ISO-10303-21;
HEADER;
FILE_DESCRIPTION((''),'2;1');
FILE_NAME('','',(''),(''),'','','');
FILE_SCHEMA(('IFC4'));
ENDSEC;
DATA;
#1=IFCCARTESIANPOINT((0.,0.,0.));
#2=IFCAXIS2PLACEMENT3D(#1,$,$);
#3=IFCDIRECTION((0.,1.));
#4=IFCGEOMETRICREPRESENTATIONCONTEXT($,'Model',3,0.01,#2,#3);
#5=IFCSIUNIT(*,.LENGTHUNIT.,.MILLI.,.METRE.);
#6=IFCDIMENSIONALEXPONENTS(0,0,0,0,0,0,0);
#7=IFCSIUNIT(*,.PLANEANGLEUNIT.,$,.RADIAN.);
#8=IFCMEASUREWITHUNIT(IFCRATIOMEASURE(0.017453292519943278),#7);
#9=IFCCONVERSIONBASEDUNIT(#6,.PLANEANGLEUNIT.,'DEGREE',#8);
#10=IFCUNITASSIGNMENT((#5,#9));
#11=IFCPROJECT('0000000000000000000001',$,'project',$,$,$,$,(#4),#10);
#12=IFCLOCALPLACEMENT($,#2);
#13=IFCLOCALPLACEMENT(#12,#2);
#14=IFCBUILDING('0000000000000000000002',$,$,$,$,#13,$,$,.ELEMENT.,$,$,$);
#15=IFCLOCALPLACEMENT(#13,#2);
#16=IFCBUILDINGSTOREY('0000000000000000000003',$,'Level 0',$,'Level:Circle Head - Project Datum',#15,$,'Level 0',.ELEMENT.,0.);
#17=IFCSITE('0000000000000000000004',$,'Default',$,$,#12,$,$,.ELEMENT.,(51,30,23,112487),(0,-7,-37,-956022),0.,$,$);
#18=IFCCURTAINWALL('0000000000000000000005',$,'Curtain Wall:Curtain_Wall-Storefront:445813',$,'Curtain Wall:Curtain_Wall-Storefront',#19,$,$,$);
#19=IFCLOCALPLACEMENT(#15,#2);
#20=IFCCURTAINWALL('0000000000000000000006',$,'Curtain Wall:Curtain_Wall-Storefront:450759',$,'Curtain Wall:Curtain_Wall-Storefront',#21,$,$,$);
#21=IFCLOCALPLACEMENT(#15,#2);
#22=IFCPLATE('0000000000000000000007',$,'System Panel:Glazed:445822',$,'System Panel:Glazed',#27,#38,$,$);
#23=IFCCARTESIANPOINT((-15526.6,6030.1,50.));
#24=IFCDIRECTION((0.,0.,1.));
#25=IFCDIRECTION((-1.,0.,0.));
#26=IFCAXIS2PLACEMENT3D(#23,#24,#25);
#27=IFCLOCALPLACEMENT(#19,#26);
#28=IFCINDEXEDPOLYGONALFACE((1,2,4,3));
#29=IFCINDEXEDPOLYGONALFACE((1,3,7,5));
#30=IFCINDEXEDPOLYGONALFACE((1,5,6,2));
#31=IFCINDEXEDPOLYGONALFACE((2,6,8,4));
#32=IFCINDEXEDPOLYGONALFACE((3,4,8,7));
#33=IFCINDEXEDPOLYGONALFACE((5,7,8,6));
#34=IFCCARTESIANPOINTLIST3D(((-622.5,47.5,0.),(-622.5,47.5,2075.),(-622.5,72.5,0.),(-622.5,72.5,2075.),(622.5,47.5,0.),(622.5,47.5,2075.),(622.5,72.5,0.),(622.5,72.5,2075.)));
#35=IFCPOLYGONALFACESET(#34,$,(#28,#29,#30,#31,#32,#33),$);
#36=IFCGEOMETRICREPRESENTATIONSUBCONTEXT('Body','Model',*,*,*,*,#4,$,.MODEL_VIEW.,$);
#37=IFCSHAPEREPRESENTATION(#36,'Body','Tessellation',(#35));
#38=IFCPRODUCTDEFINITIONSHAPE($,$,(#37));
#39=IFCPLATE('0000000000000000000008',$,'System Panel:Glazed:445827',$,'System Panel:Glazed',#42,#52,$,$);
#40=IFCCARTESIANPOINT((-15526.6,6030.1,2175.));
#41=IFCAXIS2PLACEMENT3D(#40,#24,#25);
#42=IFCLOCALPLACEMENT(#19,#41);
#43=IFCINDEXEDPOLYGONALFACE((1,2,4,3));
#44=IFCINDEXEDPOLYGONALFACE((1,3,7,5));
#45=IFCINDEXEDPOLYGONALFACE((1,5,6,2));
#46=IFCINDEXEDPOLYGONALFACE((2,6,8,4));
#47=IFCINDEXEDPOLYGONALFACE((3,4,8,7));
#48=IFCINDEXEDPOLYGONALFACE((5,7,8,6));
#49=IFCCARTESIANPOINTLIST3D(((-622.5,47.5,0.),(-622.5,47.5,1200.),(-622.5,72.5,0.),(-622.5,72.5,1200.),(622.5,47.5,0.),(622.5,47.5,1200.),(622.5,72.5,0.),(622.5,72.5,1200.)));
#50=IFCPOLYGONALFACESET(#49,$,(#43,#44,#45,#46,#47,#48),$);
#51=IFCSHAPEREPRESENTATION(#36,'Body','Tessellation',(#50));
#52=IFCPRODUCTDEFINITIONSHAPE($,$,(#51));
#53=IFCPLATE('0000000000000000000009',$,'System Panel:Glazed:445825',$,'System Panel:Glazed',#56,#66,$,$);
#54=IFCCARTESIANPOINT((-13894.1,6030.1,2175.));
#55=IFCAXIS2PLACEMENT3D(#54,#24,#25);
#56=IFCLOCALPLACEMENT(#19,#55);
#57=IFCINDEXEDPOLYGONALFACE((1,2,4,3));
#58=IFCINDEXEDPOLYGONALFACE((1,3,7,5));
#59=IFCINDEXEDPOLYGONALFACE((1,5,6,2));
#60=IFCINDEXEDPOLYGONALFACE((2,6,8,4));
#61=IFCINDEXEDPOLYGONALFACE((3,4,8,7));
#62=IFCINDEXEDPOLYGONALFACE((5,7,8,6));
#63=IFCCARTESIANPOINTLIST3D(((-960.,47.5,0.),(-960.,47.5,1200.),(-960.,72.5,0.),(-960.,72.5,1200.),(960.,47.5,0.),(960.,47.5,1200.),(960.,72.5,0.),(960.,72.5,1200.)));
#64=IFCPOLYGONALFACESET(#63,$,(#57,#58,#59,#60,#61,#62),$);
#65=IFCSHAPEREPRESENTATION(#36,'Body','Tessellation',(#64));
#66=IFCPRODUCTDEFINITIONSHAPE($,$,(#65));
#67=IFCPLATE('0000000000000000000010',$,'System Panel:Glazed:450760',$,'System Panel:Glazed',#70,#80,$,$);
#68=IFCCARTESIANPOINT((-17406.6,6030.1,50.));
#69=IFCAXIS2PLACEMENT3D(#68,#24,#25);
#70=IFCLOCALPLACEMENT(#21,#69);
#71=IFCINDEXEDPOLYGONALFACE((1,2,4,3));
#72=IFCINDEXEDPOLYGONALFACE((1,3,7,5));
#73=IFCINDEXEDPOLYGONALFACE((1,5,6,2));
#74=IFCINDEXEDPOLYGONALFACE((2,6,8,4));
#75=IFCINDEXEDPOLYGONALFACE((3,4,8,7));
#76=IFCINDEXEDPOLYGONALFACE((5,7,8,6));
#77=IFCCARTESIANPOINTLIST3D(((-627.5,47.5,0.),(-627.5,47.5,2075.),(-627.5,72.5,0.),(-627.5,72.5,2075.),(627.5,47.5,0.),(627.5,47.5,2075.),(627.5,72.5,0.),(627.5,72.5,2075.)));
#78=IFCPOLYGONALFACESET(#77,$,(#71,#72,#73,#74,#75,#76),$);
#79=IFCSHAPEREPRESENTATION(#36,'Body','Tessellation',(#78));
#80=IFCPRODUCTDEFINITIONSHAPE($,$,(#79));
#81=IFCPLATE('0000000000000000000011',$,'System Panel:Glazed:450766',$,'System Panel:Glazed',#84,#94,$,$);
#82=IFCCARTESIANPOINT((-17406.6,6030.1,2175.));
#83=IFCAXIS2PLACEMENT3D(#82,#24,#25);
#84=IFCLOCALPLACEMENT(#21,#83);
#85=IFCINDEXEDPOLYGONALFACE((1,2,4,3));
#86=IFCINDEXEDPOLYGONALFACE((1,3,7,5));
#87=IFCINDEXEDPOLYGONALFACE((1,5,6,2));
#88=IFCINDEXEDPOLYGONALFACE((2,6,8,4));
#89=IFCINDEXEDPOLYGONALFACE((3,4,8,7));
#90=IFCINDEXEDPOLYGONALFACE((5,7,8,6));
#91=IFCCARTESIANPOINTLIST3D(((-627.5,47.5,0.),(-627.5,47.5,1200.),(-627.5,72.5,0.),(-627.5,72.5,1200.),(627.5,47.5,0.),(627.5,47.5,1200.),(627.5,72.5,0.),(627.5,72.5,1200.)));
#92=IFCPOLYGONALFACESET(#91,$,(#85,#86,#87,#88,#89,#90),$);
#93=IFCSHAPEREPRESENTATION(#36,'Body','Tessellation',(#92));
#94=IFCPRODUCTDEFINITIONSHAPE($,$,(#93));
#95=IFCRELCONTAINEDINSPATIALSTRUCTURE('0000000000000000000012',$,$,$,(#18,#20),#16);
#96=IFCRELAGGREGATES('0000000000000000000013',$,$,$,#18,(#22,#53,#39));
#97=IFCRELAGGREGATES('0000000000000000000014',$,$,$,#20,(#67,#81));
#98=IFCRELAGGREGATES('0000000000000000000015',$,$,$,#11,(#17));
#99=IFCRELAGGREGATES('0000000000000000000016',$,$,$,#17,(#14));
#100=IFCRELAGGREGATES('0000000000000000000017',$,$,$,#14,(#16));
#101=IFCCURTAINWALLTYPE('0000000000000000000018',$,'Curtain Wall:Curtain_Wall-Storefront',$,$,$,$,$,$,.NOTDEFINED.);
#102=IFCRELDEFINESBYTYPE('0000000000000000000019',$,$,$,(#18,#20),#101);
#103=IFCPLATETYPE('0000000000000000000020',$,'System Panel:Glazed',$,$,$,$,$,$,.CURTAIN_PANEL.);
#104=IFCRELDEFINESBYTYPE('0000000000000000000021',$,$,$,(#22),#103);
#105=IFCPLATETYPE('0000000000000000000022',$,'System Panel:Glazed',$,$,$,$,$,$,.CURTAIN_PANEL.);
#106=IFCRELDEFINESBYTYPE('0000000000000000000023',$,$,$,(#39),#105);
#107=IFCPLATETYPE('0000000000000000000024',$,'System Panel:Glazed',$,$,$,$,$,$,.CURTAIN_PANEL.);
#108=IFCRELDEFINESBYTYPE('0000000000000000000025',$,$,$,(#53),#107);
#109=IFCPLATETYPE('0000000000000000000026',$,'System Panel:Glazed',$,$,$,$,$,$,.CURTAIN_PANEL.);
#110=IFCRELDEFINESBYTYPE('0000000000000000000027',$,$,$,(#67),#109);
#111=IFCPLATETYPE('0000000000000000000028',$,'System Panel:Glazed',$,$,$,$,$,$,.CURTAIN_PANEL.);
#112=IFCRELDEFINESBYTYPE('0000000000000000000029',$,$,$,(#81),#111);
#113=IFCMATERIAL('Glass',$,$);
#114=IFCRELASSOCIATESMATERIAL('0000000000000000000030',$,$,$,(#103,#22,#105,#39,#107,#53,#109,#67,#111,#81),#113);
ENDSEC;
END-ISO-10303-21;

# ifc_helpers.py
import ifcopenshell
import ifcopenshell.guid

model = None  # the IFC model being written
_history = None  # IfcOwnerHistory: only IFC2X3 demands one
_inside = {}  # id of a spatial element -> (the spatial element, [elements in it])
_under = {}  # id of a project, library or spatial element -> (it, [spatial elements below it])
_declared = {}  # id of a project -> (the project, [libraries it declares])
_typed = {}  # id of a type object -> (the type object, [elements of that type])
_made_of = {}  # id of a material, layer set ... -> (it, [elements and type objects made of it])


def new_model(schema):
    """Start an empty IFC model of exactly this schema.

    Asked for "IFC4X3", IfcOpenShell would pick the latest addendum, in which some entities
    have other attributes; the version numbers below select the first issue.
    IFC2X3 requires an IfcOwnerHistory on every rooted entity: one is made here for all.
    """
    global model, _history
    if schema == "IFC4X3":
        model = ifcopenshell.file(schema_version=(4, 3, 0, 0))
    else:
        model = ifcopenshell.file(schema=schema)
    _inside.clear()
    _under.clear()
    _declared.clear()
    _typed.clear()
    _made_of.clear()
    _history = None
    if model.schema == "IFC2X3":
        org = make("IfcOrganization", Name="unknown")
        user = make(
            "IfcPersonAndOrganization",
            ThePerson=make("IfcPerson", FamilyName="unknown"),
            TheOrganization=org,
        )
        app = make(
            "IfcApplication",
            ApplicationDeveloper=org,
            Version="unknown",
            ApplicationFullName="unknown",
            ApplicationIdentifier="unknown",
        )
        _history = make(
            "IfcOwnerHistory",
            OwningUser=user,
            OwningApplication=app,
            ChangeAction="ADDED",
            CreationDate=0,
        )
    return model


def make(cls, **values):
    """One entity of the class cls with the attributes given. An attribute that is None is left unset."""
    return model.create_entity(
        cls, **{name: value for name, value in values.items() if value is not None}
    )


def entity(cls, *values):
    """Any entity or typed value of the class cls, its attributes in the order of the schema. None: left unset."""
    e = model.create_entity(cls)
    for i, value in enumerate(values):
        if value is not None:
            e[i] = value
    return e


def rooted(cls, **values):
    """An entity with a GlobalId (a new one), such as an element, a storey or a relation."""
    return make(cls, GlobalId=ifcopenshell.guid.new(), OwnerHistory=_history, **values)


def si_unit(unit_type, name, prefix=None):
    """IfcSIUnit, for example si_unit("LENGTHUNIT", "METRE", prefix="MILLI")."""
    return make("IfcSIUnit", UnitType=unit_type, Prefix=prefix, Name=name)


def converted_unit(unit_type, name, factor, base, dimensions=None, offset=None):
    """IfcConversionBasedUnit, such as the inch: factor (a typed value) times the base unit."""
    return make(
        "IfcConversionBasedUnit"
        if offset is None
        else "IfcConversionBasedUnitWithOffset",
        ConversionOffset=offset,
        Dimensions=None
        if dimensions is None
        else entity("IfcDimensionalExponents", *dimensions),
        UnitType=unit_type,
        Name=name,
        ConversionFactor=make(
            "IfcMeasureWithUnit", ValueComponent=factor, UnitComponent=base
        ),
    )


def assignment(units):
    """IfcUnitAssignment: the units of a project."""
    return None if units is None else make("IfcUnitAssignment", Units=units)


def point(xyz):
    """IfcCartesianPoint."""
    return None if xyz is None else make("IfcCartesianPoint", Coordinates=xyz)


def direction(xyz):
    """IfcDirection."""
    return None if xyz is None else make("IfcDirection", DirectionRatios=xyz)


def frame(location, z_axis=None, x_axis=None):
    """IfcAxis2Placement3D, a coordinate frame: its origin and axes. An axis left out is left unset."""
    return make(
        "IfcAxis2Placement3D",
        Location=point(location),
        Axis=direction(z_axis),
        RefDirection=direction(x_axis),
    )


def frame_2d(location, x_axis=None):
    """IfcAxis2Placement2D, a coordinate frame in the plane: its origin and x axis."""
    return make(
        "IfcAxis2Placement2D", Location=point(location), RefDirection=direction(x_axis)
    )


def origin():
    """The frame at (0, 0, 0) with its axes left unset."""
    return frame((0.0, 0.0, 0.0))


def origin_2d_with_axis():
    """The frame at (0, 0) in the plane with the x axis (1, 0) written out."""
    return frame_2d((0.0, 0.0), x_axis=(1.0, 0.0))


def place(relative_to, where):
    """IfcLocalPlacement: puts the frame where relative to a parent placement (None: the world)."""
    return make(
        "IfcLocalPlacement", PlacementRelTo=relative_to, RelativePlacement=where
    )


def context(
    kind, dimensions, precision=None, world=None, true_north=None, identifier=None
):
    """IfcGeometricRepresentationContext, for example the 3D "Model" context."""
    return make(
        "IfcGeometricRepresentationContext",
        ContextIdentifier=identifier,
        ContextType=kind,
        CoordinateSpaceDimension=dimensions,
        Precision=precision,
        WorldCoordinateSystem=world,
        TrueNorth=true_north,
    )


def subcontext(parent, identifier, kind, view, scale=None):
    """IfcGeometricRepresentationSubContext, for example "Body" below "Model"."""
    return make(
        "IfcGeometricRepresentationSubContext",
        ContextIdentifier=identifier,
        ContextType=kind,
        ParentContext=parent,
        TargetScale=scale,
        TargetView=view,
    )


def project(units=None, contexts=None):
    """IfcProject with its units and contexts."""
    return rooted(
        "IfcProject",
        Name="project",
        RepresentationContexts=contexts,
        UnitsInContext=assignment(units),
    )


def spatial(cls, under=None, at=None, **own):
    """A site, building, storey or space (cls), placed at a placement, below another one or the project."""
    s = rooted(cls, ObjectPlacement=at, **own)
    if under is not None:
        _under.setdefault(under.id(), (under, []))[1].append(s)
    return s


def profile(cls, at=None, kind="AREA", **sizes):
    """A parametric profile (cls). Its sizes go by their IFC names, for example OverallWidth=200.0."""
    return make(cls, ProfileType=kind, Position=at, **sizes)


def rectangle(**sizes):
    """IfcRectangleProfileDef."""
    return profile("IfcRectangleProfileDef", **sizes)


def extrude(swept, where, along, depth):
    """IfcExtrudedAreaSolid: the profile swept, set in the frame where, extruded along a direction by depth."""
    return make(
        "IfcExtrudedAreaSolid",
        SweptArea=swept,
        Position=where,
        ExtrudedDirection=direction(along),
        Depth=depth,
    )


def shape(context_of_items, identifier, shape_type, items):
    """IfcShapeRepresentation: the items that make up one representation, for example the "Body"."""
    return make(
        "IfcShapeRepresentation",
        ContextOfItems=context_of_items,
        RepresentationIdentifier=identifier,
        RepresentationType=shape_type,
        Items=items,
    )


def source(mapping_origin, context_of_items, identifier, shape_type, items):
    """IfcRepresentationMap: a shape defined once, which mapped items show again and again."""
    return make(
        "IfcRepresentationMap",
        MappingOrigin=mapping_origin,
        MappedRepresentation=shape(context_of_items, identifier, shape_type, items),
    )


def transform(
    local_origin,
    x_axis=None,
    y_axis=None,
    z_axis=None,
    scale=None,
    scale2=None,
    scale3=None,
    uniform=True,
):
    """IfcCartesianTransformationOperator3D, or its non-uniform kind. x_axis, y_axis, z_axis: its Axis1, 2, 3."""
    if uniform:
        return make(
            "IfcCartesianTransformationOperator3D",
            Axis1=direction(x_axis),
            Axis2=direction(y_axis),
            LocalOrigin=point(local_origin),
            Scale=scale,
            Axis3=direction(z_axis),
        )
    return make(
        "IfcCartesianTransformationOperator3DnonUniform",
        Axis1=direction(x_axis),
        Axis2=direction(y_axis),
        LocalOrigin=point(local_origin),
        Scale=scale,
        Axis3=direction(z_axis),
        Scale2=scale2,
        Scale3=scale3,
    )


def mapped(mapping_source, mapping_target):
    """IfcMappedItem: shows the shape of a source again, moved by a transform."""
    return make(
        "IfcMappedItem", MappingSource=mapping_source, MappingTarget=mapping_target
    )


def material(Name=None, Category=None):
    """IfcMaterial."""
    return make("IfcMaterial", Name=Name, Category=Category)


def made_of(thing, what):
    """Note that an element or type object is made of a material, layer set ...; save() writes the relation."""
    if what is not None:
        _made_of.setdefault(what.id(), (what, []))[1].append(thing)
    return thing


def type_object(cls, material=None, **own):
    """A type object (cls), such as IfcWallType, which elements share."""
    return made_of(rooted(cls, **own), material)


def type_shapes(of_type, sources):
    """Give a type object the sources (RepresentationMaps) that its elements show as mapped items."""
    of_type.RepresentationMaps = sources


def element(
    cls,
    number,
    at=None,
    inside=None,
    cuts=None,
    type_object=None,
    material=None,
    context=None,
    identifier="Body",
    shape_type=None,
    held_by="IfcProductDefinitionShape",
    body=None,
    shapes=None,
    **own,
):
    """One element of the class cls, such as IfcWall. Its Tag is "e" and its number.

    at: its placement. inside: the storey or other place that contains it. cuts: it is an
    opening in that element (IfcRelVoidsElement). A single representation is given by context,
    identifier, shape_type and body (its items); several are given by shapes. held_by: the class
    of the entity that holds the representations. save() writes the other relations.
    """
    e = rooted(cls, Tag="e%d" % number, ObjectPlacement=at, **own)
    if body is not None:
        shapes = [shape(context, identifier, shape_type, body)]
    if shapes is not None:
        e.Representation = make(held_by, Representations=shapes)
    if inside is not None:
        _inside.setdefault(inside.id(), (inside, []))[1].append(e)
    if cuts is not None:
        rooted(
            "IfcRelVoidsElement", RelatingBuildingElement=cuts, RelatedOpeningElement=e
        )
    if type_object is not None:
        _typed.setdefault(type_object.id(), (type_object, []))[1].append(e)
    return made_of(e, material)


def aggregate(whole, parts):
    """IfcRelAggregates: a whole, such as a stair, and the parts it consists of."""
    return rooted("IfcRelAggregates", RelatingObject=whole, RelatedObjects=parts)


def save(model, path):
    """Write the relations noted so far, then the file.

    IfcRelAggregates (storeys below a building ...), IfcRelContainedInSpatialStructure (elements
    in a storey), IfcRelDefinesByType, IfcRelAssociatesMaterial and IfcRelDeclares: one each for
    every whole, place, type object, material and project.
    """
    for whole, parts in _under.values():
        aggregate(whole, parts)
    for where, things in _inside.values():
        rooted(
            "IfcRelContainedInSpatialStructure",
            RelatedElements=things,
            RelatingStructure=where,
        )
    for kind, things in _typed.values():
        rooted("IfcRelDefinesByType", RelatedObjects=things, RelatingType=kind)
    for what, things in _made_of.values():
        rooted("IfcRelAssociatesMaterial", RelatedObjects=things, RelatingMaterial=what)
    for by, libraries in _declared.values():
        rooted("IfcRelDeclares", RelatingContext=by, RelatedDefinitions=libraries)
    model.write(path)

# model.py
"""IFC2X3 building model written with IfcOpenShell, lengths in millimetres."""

from ifc_helpers import new_model, entity, si_unit, converted_unit, direction, frame, origin, origin_2d_with_axis, place, context, subcontext, project, spatial, rectangle, extrude, source, transform, mapped, material, type_object, type_shapes, element, aggregate, save


model = new_model("IFC2X3")

# Units and contexts
model_context = context("Model", 3, precision=0.01, world=origin(), true_north=direction((0.0, 1.0)))
body_context = subcontext(model_context, "Body", "Model", "MODEL_VIEW")
ifc_project = project(units=[si_unit("LENGTHUNIT", "METRE", prefix="MILLI"), converted_unit("PLANEANGLEUNIT", "DEGREE", entity("IfcRatioMeasure", 0.017453292519943278), si_unit("PLANEANGLEUNIT", "RADIAN"), dimensions=[0, 0, 0, 0, 0, 0, 0])], contexts=[model_context])

# Site, building, storey
site_placement = place(None, origin())
site = spatial("IfcSite", under=ifc_project, at=site_placement, Name="Default", CompositionType="ELEMENT", RefLatitude=(51, 30, 23, 112487), RefLongitude=(0, -7, -37, -956022), RefElevation=0.0)
building_placement = place(site_placement, origin())
building = spatial("IfcBuilding", under=site, at=building_placement, CompositionType="ELEMENT")
storey_placement = place(building_placement, origin())
storey = spatial("IfcBuildingStorey", under=building, at=storey_placement, Name="Level 0", ObjectType="Level:Circle Head - Project Datum", LongName="Level 0", CompositionType="ELEMENT", Elevation=0.0)

# Curtain walls
curtain_wall_type = type_object("IfcCurtainWallType", Name="Curtain Wall:Curtain_Wall-Storefront", PredefinedType="NOTDEFINED")
curtain_wall_1_placement = place(storey_placement, origin())
curtain_wall_1 = element("IfcCurtainWall", 1, at=curtain_wall_1_placement, inside=storey, type_object=curtain_wall_type, Name="Curtain Wall:Curtain_Wall-Storefront:445813", ObjectType="Curtain Wall:Curtain_Wall-Storefront")
curtain_wall_2_placement = place(storey_placement, origin())
curtain_wall_2 = element("IfcCurtainWall", 2, at=curtain_wall_2_placement, inside=storey, type_object=curtain_wall_type, Name="Curtain Wall:Curtain_Wall-Storefront:450759", ObjectType="Curtain Wall:Curtain_Wall-Storefront")

# Plates
ifc_material_1 = material(Name="Glass")
plate_type_1 = type_object("IfcPlateType", Name="System Panel:Glazed", PredefinedType="CURTAIN_PANEL", material=ifc_material_1)
shared_shape_1 = source(origin(), body_context, "Body", "SweptSolid", [
    extrude(rectangle(XDim=25.0, YDim=1245.0, at=origin_2d_with_axis()), frame((0.0, 60.0, 0.0), z_axis=(0.0, 0.0, 1.0), x_axis=(0.0, 1.0, 0.0)), (0.0, 0.0, 1.0), 2075.0),
])
type_shapes(plate_type_1, [shared_shape_1])
plate_1_placement = place(curtain_wall_1_placement, frame((-15526.6, 6030.1, 50.0), z_axis=(0.0, 0.0, 1.0), x_axis=(-1.0, 0.0, 0.0)))
plate_1 = element("IfcPlate", 3, at=plate_1_placement, type_object=plate_type_1, material=ifc_material_1, Name="System Panel:Glazed:445822", ObjectType="System Panel:Glazed", context=body_context, shape_type="MappedRepresentation", body=[
    mapped(shared_shape_1, transform((0.0, 0.0, 0.0), scale=1.0)),
])
plate_type_2 = type_object("IfcPlateType", Name="System Panel:Glazed", PredefinedType="CURTAIN_PANEL", material=ifc_material_1)
shared_shape_2 = source(origin(), body_context, "Body", "SweptSolid", [
    extrude(rectangle(XDim=25.0, YDim=1245.0, at=origin_2d_with_axis()), frame((0.0, 60.0, 0.0), z_axis=(0.0, 0.0, 1.0), x_axis=(0.0, 1.0, 0.0)), (0.0, 0.0, 1.0), 1200.0),
])
type_shapes(plate_type_2, [shared_shape_2])
plate_2_placement = place(curtain_wall_1_placement, frame((-15526.6, 6030.1, 2175.0), z_axis=(0.0, 0.0, 1.0), x_axis=(-1.0, 0.0, 0.0)))
plate_2 = element("IfcPlate", 4, at=plate_2_placement, type_object=plate_type_2, material=ifc_material_1, Name="System Panel:Glazed:445827", ObjectType="System Panel:Glazed", context=body_context, shape_type="MappedRepresentation", body=[
    mapped(shared_shape_2, transform((0.0, 0.0, 0.0), scale=1.0)),
])
plate_type_3 = type_object("IfcPlateType", Name="System Panel:Glazed", PredefinedType="CURTAIN_PANEL", material=ifc_material_1)
shared_shape_3 = source(origin(), body_context, "Body", "SweptSolid", [
    extrude(rectangle(XDim=25.0, YDim=1920.0, at=origin_2d_with_axis()), frame((0.0, 60.0, 0.0), z_axis=(0.0, 0.0, 1.0), x_axis=(0.0, 1.0, 0.0)), (0.0, 0.0, 1.0), 1200.0),
])
type_shapes(plate_type_3, [shared_shape_3])
plate_3_placement = place(curtain_wall_1_placement, frame((-13894.1, 6030.1, 2175.0), z_axis=(0.0, 0.0, 1.0), x_axis=(-1.0, 0.0, 0.0)))
plate_3 = element("IfcPlate", 5, at=plate_3_placement, type_object=plate_type_3, material=ifc_material_1, Name="System Panel:Glazed:445825", ObjectType="System Panel:Glazed", context=body_context, shape_type="MappedRepresentation", body=[
    mapped(shared_shape_3, transform((0.0, 0.0, 0.0), scale=1.0)),
])
aggregate(curtain_wall_1, [plate_1, plate_3, plate_2])
plate_type_4 = type_object("IfcPlateType", Name="System Panel:Glazed", PredefinedType="CURTAIN_PANEL", material=ifc_material_1)
shared_shape_4 = source(origin(), body_context, "Body", "SweptSolid", [
    extrude(rectangle(XDim=25.0, YDim=1255.0, at=origin_2d_with_axis()), frame((0.0, 60.0, 0.0), z_axis=(0.0, 0.0, 1.0), x_axis=(0.0, 1.0, 0.0)), (0.0, 0.0, 1.0), 2075.0),
])
type_shapes(plate_type_4, [shared_shape_4])
plate_4_placement = place(curtain_wall_2_placement, frame((-17406.6, 6030.1, 50.0), z_axis=(0.0, 0.0, 1.0), x_axis=(-1.0, 0.0, 0.0)))
plate_4 = element("IfcPlate", 6, at=plate_4_placement, type_object=plate_type_4, material=ifc_material_1, Name="System Panel:Glazed:450760", ObjectType="System Panel:Glazed", context=body_context, shape_type="MappedRepresentation", body=[
    mapped(shared_shape_4, transform((0.0, 0.0, 0.0), scale=1.0)),
])
plate_type_5 = type_object("IfcPlateType", Name="System Panel:Glazed", PredefinedType="CURTAIN_PANEL", material=ifc_material_1)
shared_shape_5 = source(origin(), body_context, "Body", "SweptSolid", [
    extrude(rectangle(XDim=25.0, YDim=1255.0, at=origin_2d_with_axis()), frame((0.0, 60.0, 0.0), z_axis=(0.0, 0.0, 1.0), x_axis=(0.0, 1.0, 0.0)), (0.0, 0.0, 1.0), 1200.0),
])
type_shapes(plate_type_5, [shared_shape_5])
plate_5_placement = place(curtain_wall_2_placement, frame((-17406.6, 6030.1, 2175.0), z_axis=(0.0, 0.0, 1.0), x_axis=(-1.0, 0.0, 0.0)))
plate_5 = element("IfcPlate", 7, at=plate_5_placement, type_object=plate_type_5, material=ifc_material_1, Name="System Panel:Glazed:450766", ObjectType="System Panel:Glazed", context=body_context, shape_type="MappedRepresentation", body=[
    mapped(shared_shape_5, transform((0.0, 0.0, 0.0), scale=1.0)),
])
aggregate(curtain_wall_2, [plate_4, plate_5])

save(model, "model.ifc")
